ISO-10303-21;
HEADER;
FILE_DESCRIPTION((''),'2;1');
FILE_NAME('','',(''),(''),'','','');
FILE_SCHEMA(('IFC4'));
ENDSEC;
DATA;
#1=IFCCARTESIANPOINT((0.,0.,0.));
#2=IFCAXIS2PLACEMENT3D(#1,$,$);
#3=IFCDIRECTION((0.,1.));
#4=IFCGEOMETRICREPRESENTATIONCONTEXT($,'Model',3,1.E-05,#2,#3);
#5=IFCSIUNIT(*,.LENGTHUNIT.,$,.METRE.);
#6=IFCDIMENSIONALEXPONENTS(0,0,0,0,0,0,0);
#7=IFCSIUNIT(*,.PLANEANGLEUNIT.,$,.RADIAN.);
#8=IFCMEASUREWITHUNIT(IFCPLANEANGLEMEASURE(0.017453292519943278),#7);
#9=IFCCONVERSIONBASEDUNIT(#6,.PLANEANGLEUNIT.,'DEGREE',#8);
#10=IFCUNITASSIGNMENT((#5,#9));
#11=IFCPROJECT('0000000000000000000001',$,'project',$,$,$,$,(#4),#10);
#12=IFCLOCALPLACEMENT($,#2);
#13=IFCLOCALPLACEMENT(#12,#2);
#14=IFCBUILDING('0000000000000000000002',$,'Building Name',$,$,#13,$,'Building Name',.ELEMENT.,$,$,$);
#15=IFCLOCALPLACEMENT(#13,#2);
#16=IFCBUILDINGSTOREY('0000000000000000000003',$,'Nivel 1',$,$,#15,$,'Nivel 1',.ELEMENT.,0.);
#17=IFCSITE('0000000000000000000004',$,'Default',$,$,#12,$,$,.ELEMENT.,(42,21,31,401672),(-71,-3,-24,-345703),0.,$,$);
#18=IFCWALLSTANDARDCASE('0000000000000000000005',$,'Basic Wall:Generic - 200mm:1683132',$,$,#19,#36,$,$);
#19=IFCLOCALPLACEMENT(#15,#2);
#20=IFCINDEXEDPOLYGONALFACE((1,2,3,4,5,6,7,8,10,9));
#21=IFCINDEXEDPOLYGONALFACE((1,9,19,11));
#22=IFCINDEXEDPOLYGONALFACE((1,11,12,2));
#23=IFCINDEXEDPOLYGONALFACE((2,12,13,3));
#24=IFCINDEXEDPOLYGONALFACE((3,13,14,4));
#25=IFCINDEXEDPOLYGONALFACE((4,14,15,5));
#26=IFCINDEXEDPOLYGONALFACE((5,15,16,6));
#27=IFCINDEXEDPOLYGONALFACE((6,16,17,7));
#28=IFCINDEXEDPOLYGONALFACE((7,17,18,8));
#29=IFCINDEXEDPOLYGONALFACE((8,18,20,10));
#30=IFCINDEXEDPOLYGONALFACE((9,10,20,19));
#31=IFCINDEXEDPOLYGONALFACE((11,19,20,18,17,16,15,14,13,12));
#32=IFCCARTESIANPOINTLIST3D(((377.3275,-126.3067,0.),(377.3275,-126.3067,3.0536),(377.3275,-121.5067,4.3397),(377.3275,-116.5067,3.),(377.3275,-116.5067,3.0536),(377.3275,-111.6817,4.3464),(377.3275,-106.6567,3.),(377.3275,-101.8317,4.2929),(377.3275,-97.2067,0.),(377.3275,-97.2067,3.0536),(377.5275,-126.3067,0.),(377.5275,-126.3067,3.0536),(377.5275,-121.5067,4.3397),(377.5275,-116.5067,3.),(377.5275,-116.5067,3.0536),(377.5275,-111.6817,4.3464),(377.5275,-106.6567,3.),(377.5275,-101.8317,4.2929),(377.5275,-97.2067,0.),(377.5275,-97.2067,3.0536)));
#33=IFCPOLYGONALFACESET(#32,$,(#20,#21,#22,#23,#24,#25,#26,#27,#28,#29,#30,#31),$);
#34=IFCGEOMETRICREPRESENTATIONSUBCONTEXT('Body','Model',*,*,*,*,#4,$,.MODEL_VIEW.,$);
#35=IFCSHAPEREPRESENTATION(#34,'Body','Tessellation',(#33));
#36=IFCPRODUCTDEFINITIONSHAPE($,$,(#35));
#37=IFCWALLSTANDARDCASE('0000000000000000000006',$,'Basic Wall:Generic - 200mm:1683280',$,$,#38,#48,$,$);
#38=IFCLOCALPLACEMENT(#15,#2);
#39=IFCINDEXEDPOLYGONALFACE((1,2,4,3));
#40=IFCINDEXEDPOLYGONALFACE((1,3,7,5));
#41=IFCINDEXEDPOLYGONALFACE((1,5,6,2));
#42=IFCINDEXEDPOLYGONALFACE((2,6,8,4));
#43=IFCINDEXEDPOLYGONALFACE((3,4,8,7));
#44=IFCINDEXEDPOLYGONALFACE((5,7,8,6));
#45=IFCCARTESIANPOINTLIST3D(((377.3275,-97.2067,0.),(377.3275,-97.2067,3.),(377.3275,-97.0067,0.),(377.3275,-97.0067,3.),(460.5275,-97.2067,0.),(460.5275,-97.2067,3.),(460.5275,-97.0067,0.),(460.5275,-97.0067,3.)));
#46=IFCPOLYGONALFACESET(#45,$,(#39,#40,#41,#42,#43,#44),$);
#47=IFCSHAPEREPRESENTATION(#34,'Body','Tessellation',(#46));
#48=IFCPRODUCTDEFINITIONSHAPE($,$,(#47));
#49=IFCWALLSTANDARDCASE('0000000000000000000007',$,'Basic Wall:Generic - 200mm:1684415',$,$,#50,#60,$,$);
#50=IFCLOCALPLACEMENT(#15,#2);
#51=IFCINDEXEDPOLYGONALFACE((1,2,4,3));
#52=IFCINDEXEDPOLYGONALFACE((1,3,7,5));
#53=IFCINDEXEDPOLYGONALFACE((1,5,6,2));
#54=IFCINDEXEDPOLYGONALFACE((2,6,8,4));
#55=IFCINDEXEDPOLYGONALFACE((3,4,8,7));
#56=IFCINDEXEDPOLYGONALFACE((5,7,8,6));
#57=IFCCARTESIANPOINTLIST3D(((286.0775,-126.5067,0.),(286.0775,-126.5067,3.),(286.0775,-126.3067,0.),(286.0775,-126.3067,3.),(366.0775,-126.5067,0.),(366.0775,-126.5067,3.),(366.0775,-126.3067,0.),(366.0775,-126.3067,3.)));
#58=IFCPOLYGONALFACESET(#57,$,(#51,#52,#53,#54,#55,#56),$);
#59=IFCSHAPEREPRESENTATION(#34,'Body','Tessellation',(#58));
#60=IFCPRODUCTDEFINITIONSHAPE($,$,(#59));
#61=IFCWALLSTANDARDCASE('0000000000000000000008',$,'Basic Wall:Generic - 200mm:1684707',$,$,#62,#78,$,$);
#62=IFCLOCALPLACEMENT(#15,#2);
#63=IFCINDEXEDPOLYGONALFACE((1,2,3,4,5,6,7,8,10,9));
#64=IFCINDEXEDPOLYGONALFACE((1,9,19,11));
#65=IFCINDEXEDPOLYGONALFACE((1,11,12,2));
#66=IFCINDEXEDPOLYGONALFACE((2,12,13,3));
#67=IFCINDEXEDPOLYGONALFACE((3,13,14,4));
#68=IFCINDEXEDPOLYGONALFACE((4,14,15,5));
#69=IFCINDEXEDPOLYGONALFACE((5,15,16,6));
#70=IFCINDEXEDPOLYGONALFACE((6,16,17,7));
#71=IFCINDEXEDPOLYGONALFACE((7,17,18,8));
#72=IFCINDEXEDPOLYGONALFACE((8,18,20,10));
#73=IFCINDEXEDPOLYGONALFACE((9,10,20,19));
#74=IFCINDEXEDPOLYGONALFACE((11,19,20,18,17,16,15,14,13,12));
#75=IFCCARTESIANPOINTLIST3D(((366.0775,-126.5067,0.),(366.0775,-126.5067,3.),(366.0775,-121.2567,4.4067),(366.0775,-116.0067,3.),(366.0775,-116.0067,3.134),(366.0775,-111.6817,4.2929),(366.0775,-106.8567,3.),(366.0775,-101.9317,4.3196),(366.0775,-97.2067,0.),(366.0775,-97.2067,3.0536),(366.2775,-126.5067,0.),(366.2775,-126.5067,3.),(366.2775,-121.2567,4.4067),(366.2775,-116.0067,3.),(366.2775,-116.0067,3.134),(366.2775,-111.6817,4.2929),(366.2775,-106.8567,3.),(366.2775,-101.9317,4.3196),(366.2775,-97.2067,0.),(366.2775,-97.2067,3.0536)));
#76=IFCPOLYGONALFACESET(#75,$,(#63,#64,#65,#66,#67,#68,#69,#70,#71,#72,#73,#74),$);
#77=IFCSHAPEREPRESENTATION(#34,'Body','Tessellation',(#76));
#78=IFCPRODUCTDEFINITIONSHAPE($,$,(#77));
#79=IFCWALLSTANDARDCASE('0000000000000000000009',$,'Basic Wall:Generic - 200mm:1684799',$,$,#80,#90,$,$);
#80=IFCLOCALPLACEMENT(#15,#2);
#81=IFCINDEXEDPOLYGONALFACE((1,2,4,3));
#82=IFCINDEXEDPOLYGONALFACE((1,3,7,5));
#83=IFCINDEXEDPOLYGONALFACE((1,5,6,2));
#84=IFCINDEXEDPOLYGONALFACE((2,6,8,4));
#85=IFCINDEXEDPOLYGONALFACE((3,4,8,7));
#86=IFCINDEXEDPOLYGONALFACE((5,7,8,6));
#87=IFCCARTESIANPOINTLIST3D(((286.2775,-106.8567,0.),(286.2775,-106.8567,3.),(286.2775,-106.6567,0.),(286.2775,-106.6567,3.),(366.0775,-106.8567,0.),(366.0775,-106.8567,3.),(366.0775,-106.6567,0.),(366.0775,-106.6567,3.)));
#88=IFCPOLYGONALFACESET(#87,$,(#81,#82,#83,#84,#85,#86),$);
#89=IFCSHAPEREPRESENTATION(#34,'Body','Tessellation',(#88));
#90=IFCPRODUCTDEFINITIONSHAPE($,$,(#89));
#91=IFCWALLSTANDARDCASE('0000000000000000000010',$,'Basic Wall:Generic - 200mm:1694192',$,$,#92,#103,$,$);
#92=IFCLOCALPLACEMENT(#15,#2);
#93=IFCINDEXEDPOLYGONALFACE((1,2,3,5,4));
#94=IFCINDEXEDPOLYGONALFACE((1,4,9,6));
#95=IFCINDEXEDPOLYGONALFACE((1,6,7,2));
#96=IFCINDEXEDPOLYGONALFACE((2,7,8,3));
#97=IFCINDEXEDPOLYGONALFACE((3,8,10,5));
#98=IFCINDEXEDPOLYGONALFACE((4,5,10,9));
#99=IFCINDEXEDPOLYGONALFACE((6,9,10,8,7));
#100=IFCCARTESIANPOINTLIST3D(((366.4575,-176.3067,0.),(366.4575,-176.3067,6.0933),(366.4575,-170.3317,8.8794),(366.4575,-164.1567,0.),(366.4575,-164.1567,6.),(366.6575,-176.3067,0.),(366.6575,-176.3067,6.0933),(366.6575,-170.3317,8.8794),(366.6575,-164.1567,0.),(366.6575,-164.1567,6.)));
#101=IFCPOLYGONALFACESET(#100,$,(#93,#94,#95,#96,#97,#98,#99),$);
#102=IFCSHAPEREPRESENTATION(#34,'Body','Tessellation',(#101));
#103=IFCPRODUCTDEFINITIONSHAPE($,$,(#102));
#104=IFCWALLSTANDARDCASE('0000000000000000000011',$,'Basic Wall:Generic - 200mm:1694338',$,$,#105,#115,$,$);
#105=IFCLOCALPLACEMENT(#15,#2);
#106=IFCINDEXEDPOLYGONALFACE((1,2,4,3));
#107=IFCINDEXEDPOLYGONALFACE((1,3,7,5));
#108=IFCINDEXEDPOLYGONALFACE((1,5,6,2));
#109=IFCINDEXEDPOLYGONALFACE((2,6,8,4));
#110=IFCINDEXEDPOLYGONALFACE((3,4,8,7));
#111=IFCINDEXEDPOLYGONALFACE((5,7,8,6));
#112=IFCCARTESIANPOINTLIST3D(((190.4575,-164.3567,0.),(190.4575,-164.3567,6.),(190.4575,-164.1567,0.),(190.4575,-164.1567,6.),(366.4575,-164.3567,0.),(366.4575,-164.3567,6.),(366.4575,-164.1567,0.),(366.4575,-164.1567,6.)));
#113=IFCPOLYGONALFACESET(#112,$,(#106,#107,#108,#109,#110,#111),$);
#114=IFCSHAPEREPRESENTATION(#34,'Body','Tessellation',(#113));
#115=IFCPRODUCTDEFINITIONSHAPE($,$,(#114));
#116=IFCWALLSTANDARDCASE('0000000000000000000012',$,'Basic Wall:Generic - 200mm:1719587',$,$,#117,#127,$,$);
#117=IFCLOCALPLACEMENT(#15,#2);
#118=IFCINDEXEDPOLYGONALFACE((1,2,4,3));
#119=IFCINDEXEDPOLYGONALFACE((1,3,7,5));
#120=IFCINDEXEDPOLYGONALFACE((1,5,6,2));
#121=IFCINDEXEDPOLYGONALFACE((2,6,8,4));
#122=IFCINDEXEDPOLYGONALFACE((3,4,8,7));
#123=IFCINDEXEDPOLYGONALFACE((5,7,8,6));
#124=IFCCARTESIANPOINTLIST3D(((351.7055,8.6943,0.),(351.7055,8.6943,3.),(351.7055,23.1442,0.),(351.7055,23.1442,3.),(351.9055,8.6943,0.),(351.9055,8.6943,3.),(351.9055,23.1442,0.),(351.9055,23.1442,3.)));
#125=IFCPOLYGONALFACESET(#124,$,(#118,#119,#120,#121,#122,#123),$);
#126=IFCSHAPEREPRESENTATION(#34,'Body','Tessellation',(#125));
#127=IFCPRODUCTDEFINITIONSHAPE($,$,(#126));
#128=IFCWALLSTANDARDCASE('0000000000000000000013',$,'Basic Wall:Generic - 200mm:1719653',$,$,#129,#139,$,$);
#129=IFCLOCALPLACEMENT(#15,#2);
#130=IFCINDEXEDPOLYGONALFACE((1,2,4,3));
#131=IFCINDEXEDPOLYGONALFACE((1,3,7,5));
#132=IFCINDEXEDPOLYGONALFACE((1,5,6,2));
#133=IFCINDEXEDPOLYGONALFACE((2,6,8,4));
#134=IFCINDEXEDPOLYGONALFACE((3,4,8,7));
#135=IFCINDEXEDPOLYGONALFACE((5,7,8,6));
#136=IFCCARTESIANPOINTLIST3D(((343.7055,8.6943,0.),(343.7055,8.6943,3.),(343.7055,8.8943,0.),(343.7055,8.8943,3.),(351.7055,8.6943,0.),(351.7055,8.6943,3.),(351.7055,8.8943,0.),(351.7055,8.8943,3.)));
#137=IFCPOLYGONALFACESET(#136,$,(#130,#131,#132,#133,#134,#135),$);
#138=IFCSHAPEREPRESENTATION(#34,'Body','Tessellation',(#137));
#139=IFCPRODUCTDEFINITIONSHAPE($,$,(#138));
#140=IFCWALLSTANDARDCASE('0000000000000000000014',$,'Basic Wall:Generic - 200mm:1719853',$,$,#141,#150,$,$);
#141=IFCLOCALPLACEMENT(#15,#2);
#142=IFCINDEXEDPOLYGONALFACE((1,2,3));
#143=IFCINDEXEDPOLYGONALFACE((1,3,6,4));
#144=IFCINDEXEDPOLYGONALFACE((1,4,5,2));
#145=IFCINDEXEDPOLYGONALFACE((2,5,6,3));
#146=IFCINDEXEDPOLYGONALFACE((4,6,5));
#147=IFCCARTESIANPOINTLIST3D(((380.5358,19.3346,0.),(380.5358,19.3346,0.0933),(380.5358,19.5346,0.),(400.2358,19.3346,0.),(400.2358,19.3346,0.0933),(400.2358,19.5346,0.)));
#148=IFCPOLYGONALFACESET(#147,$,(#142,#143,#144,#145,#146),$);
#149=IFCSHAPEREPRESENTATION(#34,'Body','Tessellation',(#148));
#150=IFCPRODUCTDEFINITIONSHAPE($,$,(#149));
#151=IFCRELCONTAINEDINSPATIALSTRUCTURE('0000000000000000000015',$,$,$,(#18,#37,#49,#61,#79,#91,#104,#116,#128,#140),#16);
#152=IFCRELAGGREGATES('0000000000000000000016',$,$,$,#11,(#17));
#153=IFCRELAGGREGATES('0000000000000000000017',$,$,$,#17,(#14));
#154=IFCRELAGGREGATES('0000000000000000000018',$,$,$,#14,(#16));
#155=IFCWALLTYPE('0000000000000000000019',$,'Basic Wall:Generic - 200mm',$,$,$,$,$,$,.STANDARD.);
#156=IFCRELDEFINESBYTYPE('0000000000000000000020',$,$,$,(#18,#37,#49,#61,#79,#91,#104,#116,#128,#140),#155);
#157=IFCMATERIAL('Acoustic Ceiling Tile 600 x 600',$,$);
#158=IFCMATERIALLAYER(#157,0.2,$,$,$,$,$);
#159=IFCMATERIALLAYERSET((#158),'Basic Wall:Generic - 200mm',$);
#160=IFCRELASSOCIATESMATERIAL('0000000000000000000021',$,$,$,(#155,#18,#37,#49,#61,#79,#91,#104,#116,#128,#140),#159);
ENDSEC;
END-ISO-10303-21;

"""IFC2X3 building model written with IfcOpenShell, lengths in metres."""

from ifc_helpers import new_model, entity, si_unit, converted_unit, direction, frame, frame_2d, origin, place, context, subcontext, project, spatial, polyline, rectangle, extrude, clip, bounded_halfspace, material, layer, layer_set, layer_usage, type_object, element, save


model = new_model("IFC2X3")

# Units and contexts
model_context = context("Model", 3, precision=1e-05, world=origin(), true_north=direction((0.0, 1.0)))
body_context = subcontext(model_context, "Body", "Model", "MODEL_VIEW")
ifc_project = project(units=[si_unit("LENGTHUNIT", "METRE"), converted_unit("PLANEANGLEUNIT", "DEGREE", entity("IfcPlaneAngleMeasure", 0.017453292519943278), si_unit("PLANEANGLEUNIT", "RADIAN"), dimensions=[0, 0, 0, 0, 0, 0, 0])], contexts=[model_context])

# Site, building, storey
site_placement = place(None, origin())
site = spatial("IfcSite", under=ifc_project, at=site_placement, Name="Default", CompositionType="ELEMENT", RefLatitude=(42, 21, 31, 401672), RefLongitude=(-71, -3, -24, -345703), RefElevation=0.0)
building_placement = place(site_placement, origin())
building = spatial("IfcBuilding", under=site, at=building_placement, Name="Building Name", LongName="Building Name", CompositionType="ELEMENT")
storey_placement = place(building_placement, origin())
storey = spatial("IfcBuildingStorey", under=building, at=storey_placement, Name="Nivel 1", LongName="Nivel 1", CompositionType="ELEMENT", Elevation=0.0)

# Walls
ifc_material_1 = material(Name="Acoustic Ceiling Tile 600 x 600")
ifc_layer_1 = layer(ifc_material_1, 0.2)
ifc_layer_set_1 = layer_set([ifc_layer_1], Name="Basic Wall:Generic - 200mm")
wall_type_1 = type_object("IfcWallType", Name="Basic Wall:Generic - 200mm", PredefinedType="STANDARD", material=ifc_layer_set_1)
ifc_layer_usage_1 = layer_usage(ifc_layer_set_1, "AXIS2", "NEGATIVE", 0.1)
wall_1_placement = place(storey_placement, frame((377.4275, -97.2067, 0.0), z_axis=(0.0, 0.0, 1.0), x_axis=(0.0, -1.0, 0.0)))
element("IfcWallStandardCase", 1, at=wall_1_placement, inside=storey, type_object=wall_type_1, material=ifc_layer_usage_1, Name="Basic Wall:Generic - 200mm:1683132", context=body_context, shape_type="Clipping", body=[
    clip(clip(clip(clip(clip(clip(extrude(rectangle(XDim=29.1, YDim=0.2, at=frame_2d((14.55, 0.0), x_axis=(-1.0, 0.0))), origin(), (0.0, 0.0, 1.0), 4.3464), bounded_halfspace(frame((0.0, -0.1, 3.0536), z_axis=(-0.258819, 0.0, 0.965926), x_axis=(0.0, -1.0, 0.0)), False, frame((0.0, -0.1, 3.0536)), polyline([(0.0, 0.0), (4.625, 0.0), (4.625, 0.2), (0.0, 0.2), (0.0, 0.0)]))), bounded_halfspace(frame((9.45, -0.1, 3.0), z_axis=(-0.258819, 0.0, 0.965926), x_axis=(0.0, -1.0, 0.0)), False, frame((9.45, -0.1, 3.0)), polyline([(0.0, 0.0), (5.025, 0.0), (5.025, 0.2), (0.0, 0.2), (0.0, 0.0)]))), bounded_halfspace(frame((24.3, 0.1, 4.3397), z_axis=(-0.258819, 0.0, 0.965926), x_axis=(0.0, -1.0, 0.0)), False, frame((24.3, 0.1, 4.3397)), polyline([(0.0, 0.0), (-5.0, 0.0), (-5.0, -0.2), (0.0, -0.2), (0.0, 0.0)]))), bounded_halfspace(frame((4.625, -0.1, 4.2929), z_axis=(0.258819, 0.0, 0.965926), x_axis=(0.0, 1.0, 0.0)), False, frame((4.625, -0.1, 4.2929)), polyline([(0.0, 0.0), (4.825, 0.0), (4.825, 0.2), (0.0, 0.2), (0.0, 0.0)]))), bounded_halfspace(frame((14.475, -0.1, 4.3464), z_axis=(0.258819, 0.0, 0.965926), x_axis=(0.0, 1.0, 0.0)), False, frame((14.475, -0.1, 4.3464)), polyline([(0.0, 0.0), (4.825, 0.0), (4.825, 0.2), (0.0, 0.2), (0.0, 0.0)]))), bounded_halfspace(frame((29.1, -0.1, 3.0536), z_axis=(0.258819, 0.0, 0.965926), x_axis=(0.0, 1.0, 0.0)), False, frame((29.1, -0.1, 3.0536)), polyline([(0.0, 0.0), (0.0, 0.2), (-4.8, 0.2), (-4.8, 0.0), (0.0, 0.0)]))),
])
ifc_layer_usage_2 = layer_usage(ifc_layer_set_1, "AXIS2", "NEGATIVE", 0.1)
wall_2_placement = place(storey_placement, frame((377.3275, -97.1067, 0.0)))
element("IfcWallStandardCase", 2, at=wall_2_placement, inside=storey, type_object=wall_type_1, material=ifc_layer_usage_2, Name="Basic Wall:Generic - 200mm:1683280", context=body_context, shape_type="SweptSolid", body=[
    extrude(rectangle(XDim=83.2, YDim=0.2, at=frame_2d((41.6, 0.0), x_axis=(-1.0, 0.0))), origin(), (0.0, 0.0, 1.0), 3.0),
])
ifc_layer_usage_3 = layer_usage(ifc_layer_set_1, "AXIS2", "NEGATIVE", 0.1)
wall_3_placement = place(storey_placement, frame((366.0775, -126.4067, 0.0), z_axis=(0.0, 0.0, 1.0), x_axis=(-1.0, 0.0, 0.0)))
element("IfcWallStandardCase", 3, at=wall_3_placement, inside=storey, type_object=wall_type_1, material=ifc_layer_usage_3, Name="Basic Wall:Generic - 200mm:1684415", context=body_context, shape_type="SweptSolid", body=[
    extrude(rectangle(XDim=80.0, YDim=0.2, at=frame_2d((40.0, 0.0), x_axis=(-1.0, 0.0))), origin(), (0.0, 0.0, 1.0), 3.0),
])
ifc_layer_usage_4 = layer_usage(ifc_layer_set_1, "AXIS2", "NEGATIVE", 0.1)
wall_4_placement = place(storey_placement, frame((366.1775, -97.2067, 0.0), z_axis=(0.0, 0.0, 1.0), x_axis=(0.0, -1.0, 0.0)))
element("IfcWallStandardCase", 4, at=wall_4_placement, inside=storey, type_object=wall_type_1, material=ifc_layer_usage_4, Name="Basic Wall:Generic - 200mm:1684707", context=body_context, shape_type="Clipping", body=[
    clip(clip(clip(clip(clip(clip(extrude(rectangle(XDim=29.3, YDim=0.2, at=frame_2d((14.65, 0.0), x_axis=(-1.0, 0.0))), origin(), (0.0, 0.0, 1.0), 4.4067), bounded_halfspace(frame((0.0, -0.1, 3.0536), z_axis=(-0.258819, 0.0, 0.965926), x_axis=(0.0, -1.0, 0.0)), False, frame((0.0, -0.1, 3.0536)), polyline([(0.0, 0.0), (4.725, 0.0), (4.725, 0.2), (0.0, 0.2), (0.0, 0.0)]))), bounded_halfspace(frame((9.65, -0.1, 3.0), z_axis=(-0.258819, 0.0, 0.965926), x_axis=(0.0, -1.0, 0.0)), False, frame((9.65, -0.1, 3.0)), polyline([(0.0, 0.0), (4.825, 0.0), (4.825, 0.2), (0.0, 0.2), (0.0, 0.0)]))), bounded_halfspace(frame((24.05, 0.1, 4.4067), z_axis=(-0.258819, 0.0, 0.965926), x_axis=(0.0, -1.0, 0.0)), False, frame((24.05, 0.1, 4.4067)), polyline([(0.0, 0.0), (-5.25, 0.0), (-5.25, -0.2), (0.0, -0.2), (0.0, 0.0)]))), bounded_halfspace(frame((4.725, -0.1, 4.3196), z_axis=(0.258819, 0.0, 0.965926), x_axis=(0.0, 1.0, 0.0)), False, frame((4.725, -0.1, 4.3196)), polyline([(0.0, 0.0), (4.925, 0.0), (4.925, 0.2), (0.0, 0.2), (0.0, 0.0)]))), bounded_halfspace(frame((14.475, -0.1, 4.2929), z_axis=(0.258819, 0.0, 0.965926), x_axis=(0.0, 1.0, 0.0)), False, frame((14.475, -0.1, 4.2929)), polyline([(0.0, 0.0), (4.325, 0.0), (4.325, 0.2), (0.0, 0.2), (0.0, 0.0)]))), bounded_halfspace(frame((29.3, -0.1, 3.0), z_axis=(0.258819, 0.0, 0.965926), x_axis=(0.0, 1.0, 0.0)), False, frame((29.3, -0.1, 3.0)), polyline([(0.0, 0.0), (0.0, 0.2), (-5.25, 0.2), (-5.25, 0.0), (0.0, 0.0)]))),
])
ifc_layer_usage_5 = layer_usage(ifc_layer_set_1, "AXIS2", "NEGATIVE", 0.1)
wall_5_placement = place(storey_placement, frame((366.0775, -106.7567, 0.0), z_axis=(0.0, 0.0, 1.0), x_axis=(-1.0, 0.0, 0.0)))
element("IfcWallStandardCase", 5, at=wall_5_placement, inside=storey, type_object=wall_type_1, material=ifc_layer_usage_5, Name="Basic Wall:Generic - 200mm:1684799", context=body_context, shape_type="SweptSolid", body=[
    extrude(rectangle(XDim=79.8, YDim=0.2, at=frame_2d((39.9, 0.0), x_axis=(-1.0, 0.0))), origin(), (0.0, 0.0, 1.0), 3.0),
])
ifc_layer_usage_6 = layer_usage(ifc_layer_set_1, "AXIS2", "NEGATIVE", 0.1)
wall_6_placement = place(storey_placement, frame((366.5575, -176.3067, 0.0), z_axis=(0.0, 0.0, 1.0), x_axis=(0.0, 1.0, 0.0)))
element("IfcWallStandardCase", 6, at=wall_6_placement, inside=storey, type_object=wall_type_1, material=ifc_layer_usage_6, Name="Basic Wall:Generic - 200mm:1694192", context=body_context, shape_type="Clipping", body=[
    clip(clip(extrude(rectangle(XDim=12.15, YDim=0.2, at=frame_2d((6.075, 0.0), x_axis=(-1.0, 0.0))), origin(), (0.0, 0.0, 1.0), 8.8794), bounded_halfspace(frame((5.975, -0.1, 8.8794), z_axis=(0.422618, 0.0, 0.906308), x_axis=(0.0, 1.0, 0.0)), False, frame((5.975, -0.1, 8.8794)), polyline([(0.0, 0.0), (6.175, 0.0), (6.175, 0.2), (0.0, 0.2), (0.0, 0.0)]))), bounded_halfspace(frame((0.0, -0.1, 6.0933), z_axis=(-0.422618, 0.0, 0.906308), x_axis=(0.0, -1.0, 0.0)), False, frame((0.0, -0.1, 6.0933)), polyline([(0.0, 0.0), (5.975, 0.0), (5.975, 0.2), (0.0, 0.2), (0.0, 0.0)]))),
])
ifc_layer_usage_7 = layer_usage(ifc_layer_set_1, "AXIS2", "NEGATIVE", 0.1)
wall_7_placement = place(storey_placement, frame((366.4575, -164.2567, 0.0), z_axis=(0.0, 0.0, 1.0), x_axis=(-1.0, 0.0, 0.0)))
element("IfcWallStandardCase", 7, at=wall_7_placement, inside=storey, type_object=wall_type_1, material=ifc_layer_usage_7, Name="Basic Wall:Generic - 200mm:1694338", context=body_context, shape_type="SweptSolid", body=[
    extrude(rectangle(XDim=176.0, YDim=0.2, at=frame_2d((88.0, 0.0), x_axis=(-1.0, 0.0))), origin(), (0.0, 0.0, 1.0), 6.0),
])
ifc_layer_usage_8 = layer_usage(ifc_layer_set_1, "AXIS2", "NEGATIVE", 0.1)
wall_8_placement = place(storey_placement, frame((351.8055, 23.1442, 0.0), z_axis=(0.0, 0.0, 1.0), x_axis=(0.0, -1.0, 0.0)))
element("IfcWallStandardCase", 8, at=wall_8_placement, inside=storey, type_object=wall_type_1, material=ifc_layer_usage_8, Name="Basic Wall:Generic - 200mm:1719587", context=body_context, shape_type="SweptSolid", body=[
    extrude(rectangle(XDim=14.45, YDim=0.2, at=frame_2d((7.225, 0.0), x_axis=(-1.0, 0.0))), origin(), (0.0, 0.0, 1.0), 3.0),
])
ifc_layer_usage_9 = layer_usage(ifc_layer_set_1, "AXIS2", "NEGATIVE", 0.1)
wall_9_placement = place(storey_placement, frame((351.7055, 8.7943, 0.0), z_axis=(0.0, 0.0, 1.0), x_axis=(-1.0, 0.0, 0.0)))
element("IfcWallStandardCase", 9, at=wall_9_placement, inside=storey, type_object=wall_type_1, material=ifc_layer_usage_9, Name="Basic Wall:Generic - 200mm:1719653", context=body_context, shape_type="SweptSolid", body=[
    extrude(rectangle(XDim=8.0, YDim=0.2, at=frame_2d((4.0, 0.0), x_axis=(-1.0, 0.0))), origin(), (0.0, 0.0, 1.0), 3.0),
])
ifc_layer_usage_10 = layer_usage(ifc_layer_set_1, "AXIS2", "NEGATIVE", 0.1)
wall_10_placement = place(storey_placement, frame((380.5358, 19.4346, 0.0)))
element("IfcWallStandardCase", 10, at=wall_10_placement, inside=storey, type_object=wall_type_1, material=ifc_layer_usage_10, Name="Basic Wall:Generic - 200mm:1719853", context=body_context, shape_type="Clipping", body=[
    clip(extrude(rectangle(XDim=19.7, YDim=0.2, at=frame_2d((9.85, 0.0), x_axis=(-1.0, 0.0))), origin(), (0.0, 0.0, 1.0), 0.0933), bounded_halfspace(frame((0.0, -0.1, 0.0933), z_axis=(0.0, 0.422618, 0.906308), x_axis=(-1.0, 0.0, 0.0)), False, frame((0.0, -0.1, 0.0933)), polyline([(0.0, 0.0), (0.2, 0.0), (19.5, 0.0), (19.7, 0.0), (19.7, 0.2), (0.0, 0.2), (0.0, 0.0)]))),
])

save(model, "model.ifc")
